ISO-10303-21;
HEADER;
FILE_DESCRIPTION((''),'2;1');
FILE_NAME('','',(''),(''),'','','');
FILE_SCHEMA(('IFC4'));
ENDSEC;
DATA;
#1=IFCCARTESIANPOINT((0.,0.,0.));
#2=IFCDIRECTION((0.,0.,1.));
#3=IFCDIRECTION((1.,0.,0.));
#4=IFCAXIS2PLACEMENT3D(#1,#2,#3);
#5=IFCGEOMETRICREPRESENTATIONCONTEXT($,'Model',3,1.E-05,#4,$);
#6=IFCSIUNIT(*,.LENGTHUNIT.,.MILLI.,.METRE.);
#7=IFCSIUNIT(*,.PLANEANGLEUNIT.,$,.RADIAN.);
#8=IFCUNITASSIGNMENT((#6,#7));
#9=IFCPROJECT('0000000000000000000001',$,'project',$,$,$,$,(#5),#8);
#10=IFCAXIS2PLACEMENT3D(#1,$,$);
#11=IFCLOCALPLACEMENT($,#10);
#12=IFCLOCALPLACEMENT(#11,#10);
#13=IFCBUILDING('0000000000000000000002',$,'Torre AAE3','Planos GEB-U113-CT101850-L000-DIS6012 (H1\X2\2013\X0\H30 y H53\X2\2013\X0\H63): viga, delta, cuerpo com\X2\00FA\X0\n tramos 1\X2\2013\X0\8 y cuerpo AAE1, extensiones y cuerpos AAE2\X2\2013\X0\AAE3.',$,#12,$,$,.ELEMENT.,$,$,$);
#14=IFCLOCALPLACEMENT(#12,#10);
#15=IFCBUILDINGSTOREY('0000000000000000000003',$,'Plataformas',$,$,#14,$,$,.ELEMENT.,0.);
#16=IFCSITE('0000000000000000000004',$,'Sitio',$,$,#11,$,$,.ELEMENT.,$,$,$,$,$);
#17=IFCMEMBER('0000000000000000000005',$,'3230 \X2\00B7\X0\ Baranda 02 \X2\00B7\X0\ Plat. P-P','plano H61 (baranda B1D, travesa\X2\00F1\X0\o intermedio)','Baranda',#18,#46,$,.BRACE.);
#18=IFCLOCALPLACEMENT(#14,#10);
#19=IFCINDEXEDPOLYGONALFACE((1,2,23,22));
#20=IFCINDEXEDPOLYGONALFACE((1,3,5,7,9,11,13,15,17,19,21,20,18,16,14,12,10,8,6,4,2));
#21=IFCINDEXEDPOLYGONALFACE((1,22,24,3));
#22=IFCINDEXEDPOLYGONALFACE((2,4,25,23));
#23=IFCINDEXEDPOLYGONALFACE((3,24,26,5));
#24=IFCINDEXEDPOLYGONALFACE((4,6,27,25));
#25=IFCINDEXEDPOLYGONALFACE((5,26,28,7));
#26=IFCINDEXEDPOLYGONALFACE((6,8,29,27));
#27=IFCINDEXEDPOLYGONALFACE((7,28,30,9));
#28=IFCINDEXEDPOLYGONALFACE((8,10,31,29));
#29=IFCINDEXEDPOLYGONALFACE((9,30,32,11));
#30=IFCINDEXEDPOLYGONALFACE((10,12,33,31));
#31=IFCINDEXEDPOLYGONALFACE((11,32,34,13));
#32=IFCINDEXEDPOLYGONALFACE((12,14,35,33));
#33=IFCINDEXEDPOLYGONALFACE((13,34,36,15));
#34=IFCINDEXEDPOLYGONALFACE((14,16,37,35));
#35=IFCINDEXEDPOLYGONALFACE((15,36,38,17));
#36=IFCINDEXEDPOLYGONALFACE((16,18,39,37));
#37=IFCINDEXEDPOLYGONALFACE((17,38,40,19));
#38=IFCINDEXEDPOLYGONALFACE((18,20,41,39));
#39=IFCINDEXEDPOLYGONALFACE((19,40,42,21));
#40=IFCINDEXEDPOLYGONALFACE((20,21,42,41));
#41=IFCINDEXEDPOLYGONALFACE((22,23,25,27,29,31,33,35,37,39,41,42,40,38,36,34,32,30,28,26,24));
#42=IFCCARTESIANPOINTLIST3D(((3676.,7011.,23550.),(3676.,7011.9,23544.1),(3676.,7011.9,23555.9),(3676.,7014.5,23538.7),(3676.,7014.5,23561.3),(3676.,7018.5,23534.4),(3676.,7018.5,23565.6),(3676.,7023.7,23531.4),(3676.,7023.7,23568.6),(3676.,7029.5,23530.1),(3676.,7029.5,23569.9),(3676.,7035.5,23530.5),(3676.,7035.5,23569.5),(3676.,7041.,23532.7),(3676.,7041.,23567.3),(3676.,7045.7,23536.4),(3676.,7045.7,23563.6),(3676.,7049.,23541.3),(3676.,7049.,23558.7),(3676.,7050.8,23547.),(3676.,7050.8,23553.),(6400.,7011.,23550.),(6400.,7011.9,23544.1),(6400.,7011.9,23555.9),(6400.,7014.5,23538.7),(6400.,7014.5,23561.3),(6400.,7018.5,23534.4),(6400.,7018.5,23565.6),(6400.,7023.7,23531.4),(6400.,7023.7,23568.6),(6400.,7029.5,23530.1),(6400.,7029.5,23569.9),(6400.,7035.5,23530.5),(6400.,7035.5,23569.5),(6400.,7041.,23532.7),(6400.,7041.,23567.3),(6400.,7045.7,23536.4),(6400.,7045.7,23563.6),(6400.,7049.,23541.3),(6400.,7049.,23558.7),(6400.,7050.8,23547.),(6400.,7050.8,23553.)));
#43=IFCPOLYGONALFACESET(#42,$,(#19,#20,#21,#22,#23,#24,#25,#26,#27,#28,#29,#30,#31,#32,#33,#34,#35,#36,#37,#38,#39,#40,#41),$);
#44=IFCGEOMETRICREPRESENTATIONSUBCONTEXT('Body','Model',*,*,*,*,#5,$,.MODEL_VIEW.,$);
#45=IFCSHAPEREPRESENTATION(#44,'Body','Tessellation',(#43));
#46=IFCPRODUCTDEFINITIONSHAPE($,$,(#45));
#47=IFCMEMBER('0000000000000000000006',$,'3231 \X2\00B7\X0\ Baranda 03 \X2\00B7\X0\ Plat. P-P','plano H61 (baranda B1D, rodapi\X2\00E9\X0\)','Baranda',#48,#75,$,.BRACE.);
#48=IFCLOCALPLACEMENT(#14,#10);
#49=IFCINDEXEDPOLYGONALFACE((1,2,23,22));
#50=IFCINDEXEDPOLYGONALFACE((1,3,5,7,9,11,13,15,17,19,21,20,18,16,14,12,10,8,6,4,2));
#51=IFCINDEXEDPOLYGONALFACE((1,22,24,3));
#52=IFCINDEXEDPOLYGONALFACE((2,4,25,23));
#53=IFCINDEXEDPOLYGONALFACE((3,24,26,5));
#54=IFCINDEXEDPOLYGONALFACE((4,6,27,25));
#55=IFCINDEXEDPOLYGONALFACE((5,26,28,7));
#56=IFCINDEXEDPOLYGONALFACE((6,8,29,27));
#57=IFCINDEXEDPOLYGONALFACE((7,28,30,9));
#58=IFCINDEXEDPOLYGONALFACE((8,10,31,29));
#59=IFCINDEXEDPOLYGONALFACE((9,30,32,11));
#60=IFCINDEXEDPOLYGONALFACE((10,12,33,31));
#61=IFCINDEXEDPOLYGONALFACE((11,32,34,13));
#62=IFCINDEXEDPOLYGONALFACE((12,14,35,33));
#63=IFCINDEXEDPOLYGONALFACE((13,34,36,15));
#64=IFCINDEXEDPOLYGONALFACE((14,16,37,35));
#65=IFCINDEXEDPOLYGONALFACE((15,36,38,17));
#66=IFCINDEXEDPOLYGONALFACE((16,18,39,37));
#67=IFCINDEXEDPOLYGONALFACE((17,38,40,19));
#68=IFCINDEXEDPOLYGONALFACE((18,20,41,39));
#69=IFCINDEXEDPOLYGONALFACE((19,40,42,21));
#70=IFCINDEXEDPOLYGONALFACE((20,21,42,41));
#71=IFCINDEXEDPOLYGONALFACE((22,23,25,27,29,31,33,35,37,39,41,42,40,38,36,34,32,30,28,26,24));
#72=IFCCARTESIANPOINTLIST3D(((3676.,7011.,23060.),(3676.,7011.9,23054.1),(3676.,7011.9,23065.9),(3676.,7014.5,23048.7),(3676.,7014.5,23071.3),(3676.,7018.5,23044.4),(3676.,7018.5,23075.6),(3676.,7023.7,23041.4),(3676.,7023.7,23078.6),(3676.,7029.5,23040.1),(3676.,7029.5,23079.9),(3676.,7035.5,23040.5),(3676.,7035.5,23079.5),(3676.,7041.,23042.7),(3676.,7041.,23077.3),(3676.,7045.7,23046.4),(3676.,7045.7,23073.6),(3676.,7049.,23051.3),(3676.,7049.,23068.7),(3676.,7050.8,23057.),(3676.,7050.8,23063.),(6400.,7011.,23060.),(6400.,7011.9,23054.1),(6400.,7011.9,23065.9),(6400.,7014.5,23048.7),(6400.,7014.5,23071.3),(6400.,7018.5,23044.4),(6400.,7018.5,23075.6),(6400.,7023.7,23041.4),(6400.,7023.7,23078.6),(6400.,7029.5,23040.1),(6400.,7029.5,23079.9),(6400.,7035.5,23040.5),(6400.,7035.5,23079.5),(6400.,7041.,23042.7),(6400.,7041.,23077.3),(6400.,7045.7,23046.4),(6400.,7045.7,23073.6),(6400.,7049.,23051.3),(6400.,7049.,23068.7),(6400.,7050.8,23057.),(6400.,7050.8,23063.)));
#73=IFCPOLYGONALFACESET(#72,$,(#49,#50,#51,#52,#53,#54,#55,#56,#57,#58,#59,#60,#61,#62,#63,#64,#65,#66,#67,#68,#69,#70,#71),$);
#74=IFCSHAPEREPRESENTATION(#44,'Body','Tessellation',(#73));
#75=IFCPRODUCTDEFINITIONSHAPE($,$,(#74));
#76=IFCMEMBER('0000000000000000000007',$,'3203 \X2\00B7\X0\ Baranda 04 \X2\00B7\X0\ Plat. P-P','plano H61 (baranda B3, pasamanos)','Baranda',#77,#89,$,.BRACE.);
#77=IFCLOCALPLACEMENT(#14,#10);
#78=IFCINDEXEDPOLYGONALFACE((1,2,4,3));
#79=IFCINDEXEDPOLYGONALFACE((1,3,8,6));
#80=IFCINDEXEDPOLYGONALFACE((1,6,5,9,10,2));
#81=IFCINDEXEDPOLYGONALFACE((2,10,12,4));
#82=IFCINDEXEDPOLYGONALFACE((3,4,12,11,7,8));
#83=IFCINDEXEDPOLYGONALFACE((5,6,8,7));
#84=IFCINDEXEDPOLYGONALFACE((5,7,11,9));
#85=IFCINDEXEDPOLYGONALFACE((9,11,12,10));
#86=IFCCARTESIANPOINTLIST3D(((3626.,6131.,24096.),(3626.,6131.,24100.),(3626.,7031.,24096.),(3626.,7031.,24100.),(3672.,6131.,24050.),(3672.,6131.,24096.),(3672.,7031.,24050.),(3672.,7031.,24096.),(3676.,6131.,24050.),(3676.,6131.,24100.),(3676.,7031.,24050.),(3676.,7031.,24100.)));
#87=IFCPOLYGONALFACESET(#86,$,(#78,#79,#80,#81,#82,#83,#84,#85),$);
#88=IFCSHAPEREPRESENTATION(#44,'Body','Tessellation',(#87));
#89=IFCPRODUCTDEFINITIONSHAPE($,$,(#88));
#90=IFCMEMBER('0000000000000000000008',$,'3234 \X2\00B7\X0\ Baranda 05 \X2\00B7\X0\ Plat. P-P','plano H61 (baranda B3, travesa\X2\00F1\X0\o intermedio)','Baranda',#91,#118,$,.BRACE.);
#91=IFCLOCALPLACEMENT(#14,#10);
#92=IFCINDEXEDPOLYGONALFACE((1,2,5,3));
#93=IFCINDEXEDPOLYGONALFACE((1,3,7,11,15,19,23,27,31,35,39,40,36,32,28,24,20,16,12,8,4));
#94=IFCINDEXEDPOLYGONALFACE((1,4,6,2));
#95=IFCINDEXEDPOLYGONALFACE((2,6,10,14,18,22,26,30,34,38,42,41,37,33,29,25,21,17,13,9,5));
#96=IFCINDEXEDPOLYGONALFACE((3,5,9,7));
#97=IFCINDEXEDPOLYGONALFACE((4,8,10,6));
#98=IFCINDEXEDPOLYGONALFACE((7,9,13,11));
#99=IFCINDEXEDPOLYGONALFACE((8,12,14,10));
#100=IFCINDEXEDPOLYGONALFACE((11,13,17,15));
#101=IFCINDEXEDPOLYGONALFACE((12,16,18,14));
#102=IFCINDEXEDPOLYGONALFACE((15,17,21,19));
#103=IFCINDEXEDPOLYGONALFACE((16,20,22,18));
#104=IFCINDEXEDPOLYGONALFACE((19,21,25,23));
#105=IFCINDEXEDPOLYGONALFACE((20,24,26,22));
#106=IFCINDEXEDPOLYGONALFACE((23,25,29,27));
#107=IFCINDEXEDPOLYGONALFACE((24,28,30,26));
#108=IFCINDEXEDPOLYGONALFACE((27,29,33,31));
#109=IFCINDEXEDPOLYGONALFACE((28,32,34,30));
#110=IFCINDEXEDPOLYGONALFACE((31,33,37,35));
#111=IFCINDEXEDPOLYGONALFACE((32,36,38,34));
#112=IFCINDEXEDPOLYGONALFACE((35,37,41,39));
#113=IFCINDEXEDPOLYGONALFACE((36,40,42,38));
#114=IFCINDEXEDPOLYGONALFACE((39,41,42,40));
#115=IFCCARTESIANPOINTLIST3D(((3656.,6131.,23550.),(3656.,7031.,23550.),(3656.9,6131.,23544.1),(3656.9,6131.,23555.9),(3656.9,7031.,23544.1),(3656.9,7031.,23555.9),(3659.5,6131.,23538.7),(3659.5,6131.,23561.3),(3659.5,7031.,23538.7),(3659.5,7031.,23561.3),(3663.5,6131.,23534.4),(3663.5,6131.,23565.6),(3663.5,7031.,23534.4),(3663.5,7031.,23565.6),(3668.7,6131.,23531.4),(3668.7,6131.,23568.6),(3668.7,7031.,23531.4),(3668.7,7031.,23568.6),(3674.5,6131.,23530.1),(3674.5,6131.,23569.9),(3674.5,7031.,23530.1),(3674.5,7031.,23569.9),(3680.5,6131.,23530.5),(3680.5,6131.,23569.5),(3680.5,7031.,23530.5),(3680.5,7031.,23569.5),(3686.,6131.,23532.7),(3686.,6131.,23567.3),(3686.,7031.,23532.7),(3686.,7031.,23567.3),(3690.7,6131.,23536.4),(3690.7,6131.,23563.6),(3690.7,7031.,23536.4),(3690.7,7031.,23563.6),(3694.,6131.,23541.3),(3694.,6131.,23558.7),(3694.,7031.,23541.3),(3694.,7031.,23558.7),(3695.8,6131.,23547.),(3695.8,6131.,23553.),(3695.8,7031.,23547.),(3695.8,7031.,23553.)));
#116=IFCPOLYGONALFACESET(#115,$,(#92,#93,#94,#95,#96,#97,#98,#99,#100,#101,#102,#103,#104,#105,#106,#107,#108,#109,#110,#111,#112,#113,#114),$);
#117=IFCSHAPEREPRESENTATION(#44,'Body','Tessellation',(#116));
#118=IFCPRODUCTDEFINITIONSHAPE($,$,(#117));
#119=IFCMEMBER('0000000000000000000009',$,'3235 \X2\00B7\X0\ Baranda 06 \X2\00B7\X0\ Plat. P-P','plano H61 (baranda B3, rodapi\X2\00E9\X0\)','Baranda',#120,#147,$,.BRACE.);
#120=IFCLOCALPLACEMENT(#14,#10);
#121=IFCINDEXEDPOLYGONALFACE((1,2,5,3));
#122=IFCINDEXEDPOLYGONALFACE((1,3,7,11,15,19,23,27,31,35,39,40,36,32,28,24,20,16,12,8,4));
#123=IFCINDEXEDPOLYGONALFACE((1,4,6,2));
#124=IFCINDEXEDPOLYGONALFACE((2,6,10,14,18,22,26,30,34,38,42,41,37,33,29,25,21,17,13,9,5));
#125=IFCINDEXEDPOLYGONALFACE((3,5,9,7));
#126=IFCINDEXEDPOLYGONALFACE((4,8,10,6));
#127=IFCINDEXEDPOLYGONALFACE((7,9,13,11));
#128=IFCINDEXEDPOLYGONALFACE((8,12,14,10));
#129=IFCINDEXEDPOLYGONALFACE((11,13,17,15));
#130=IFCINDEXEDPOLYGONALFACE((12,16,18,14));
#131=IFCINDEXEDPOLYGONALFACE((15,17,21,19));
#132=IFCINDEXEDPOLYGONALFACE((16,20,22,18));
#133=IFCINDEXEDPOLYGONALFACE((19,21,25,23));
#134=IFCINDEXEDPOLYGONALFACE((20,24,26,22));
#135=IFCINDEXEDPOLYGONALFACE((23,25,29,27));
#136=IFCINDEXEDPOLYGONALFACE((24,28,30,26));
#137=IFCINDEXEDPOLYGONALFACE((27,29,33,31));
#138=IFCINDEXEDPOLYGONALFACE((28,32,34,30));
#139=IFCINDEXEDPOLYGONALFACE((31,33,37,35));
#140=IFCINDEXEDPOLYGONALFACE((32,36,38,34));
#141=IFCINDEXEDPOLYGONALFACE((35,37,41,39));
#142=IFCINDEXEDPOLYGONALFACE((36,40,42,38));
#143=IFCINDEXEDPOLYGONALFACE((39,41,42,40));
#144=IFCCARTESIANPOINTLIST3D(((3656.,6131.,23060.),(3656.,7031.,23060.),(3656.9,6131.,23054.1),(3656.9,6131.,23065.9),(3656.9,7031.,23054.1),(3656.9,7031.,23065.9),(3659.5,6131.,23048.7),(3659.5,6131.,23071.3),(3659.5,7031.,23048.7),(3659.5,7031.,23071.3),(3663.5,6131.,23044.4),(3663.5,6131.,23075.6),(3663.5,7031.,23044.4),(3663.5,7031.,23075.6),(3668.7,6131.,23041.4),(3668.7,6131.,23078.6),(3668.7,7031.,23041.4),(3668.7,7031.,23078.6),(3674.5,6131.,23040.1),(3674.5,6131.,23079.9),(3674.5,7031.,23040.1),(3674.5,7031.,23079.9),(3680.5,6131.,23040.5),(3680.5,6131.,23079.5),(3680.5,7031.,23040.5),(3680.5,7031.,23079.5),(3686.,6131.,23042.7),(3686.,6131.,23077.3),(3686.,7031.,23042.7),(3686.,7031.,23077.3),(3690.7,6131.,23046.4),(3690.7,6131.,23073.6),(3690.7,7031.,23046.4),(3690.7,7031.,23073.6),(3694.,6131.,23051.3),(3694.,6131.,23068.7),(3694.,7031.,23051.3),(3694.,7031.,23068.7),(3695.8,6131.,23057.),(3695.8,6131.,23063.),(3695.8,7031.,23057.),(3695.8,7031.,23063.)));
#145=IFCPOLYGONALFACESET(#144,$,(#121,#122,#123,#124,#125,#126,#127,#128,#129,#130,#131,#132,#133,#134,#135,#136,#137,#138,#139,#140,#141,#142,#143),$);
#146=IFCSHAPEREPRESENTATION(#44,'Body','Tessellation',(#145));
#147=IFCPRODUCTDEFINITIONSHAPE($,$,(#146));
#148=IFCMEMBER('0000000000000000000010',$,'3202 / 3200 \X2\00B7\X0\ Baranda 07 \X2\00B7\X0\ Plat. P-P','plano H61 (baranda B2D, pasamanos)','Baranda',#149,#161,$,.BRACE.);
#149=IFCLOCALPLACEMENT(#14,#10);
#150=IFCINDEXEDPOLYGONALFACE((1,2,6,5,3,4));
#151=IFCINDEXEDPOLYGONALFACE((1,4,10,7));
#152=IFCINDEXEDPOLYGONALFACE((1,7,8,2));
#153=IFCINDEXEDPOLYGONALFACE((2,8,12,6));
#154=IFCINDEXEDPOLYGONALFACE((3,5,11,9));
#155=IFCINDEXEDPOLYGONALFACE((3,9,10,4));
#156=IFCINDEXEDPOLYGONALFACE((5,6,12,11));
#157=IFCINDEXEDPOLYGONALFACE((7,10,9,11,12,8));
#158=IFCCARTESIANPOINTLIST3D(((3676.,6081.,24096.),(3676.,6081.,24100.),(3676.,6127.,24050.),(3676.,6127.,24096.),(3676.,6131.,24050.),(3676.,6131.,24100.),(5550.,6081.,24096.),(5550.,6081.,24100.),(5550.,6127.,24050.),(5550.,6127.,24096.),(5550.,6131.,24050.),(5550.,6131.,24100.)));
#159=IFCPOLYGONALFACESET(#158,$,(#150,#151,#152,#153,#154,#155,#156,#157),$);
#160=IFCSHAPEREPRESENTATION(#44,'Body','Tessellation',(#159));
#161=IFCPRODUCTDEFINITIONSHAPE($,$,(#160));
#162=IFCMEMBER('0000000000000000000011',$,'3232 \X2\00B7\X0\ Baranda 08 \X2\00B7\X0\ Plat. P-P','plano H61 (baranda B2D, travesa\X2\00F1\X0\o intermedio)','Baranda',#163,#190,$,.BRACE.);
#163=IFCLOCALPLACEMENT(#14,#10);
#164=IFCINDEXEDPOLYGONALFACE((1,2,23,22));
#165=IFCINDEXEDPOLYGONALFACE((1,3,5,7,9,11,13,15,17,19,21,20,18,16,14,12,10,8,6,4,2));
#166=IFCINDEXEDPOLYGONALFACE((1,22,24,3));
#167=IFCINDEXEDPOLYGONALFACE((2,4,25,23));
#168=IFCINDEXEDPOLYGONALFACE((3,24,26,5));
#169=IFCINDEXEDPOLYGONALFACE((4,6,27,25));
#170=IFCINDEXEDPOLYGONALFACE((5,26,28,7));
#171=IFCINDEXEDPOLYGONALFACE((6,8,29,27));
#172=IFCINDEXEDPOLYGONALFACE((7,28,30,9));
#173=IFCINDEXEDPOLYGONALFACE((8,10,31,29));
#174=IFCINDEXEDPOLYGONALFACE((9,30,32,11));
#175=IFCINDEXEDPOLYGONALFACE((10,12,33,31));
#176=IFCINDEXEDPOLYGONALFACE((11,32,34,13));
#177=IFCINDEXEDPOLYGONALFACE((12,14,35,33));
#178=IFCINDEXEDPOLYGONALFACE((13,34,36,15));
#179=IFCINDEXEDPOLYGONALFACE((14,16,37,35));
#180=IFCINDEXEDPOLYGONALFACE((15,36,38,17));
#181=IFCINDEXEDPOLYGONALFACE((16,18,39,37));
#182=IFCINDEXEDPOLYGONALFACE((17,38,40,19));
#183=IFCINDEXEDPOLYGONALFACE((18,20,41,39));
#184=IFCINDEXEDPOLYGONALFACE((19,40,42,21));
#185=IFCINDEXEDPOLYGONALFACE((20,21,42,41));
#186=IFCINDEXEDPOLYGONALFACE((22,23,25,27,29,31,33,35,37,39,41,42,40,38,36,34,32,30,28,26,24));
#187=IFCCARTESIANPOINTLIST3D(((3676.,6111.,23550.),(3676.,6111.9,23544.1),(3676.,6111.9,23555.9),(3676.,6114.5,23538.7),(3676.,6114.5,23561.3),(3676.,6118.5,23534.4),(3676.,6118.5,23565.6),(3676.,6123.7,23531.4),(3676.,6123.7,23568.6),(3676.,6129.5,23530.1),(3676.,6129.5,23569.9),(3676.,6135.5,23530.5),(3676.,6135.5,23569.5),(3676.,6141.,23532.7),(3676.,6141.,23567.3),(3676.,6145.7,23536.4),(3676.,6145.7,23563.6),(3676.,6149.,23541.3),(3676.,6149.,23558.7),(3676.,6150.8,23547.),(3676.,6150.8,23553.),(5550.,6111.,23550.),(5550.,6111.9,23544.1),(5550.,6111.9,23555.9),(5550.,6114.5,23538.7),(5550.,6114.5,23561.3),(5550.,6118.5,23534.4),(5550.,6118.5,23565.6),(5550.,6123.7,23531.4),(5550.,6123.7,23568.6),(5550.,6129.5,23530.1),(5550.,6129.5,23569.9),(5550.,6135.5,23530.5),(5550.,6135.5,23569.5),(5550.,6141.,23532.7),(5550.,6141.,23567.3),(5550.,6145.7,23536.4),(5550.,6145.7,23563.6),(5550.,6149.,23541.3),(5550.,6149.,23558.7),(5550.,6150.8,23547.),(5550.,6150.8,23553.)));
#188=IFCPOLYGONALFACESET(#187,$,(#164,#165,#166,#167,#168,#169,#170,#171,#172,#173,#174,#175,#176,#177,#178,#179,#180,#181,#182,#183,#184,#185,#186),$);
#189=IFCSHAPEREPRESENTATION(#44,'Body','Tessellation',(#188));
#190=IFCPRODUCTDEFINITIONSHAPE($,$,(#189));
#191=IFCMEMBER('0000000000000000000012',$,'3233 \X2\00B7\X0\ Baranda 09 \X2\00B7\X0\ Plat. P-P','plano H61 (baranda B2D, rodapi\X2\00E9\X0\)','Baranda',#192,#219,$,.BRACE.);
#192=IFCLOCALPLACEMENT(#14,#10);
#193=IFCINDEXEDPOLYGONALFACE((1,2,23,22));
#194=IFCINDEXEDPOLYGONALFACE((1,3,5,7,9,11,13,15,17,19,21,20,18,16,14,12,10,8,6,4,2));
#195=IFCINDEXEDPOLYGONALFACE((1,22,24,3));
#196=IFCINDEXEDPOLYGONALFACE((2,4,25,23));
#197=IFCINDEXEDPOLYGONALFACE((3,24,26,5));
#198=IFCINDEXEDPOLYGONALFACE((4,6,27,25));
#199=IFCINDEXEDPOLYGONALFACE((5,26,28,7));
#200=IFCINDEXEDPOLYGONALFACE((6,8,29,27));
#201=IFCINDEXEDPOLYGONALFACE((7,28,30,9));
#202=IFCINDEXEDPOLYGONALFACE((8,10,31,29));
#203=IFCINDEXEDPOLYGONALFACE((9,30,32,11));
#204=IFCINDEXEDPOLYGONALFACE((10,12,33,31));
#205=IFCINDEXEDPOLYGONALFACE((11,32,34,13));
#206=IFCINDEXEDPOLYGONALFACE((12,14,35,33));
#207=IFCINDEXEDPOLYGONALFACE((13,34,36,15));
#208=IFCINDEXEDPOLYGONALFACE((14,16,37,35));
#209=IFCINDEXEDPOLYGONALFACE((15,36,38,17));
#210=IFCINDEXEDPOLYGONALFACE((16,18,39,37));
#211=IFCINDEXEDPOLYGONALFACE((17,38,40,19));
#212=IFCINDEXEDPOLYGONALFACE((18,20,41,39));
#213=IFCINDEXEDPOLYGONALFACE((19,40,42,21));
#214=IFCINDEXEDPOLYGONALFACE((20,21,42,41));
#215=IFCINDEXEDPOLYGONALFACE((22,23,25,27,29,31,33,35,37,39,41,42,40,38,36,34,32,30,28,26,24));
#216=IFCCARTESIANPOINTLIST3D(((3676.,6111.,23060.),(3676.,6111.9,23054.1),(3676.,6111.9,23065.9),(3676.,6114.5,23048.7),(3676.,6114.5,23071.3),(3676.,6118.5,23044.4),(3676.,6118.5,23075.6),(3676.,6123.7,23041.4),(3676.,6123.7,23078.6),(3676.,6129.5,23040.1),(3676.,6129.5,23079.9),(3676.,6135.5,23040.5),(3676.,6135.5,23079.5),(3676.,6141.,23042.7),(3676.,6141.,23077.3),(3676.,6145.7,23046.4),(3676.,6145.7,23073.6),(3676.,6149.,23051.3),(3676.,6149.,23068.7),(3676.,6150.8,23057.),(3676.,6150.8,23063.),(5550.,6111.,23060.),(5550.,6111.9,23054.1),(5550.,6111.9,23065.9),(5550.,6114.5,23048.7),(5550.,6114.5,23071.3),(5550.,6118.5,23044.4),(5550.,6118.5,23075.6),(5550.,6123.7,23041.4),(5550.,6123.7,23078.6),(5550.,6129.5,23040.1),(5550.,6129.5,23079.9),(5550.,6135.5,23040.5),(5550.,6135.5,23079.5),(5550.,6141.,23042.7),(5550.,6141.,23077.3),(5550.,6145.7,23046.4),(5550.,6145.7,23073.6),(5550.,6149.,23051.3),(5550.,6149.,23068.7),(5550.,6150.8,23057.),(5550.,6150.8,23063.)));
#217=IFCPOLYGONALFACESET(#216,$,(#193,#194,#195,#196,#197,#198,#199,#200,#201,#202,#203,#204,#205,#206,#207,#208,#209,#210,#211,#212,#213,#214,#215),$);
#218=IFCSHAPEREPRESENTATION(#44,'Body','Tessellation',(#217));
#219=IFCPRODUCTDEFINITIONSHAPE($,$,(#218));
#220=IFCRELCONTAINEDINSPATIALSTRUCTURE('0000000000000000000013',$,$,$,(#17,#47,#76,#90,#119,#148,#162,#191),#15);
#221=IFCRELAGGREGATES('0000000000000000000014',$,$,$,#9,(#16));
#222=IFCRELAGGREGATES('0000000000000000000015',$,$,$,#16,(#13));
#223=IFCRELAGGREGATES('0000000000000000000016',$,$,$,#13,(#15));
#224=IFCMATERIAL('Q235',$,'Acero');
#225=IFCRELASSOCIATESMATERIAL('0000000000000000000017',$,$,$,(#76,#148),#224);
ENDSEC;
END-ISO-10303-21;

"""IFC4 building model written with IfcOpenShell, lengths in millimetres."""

from ifc_helpers import new_model, si_unit, frame, frame_2d, origin, origin_with_axes, place, context, subcontext, project, spatial, circle, l_section, extrude, material, element, save


model = new_model("IFC4")

# Units and contexts
model_context = context("Model", 3, precision=1e-05, world=origin_with_axes())
body_context = subcontext(model_context, "Body", "Model", "MODEL_VIEW")
ifc_project = project(units=[si_unit("LENGTHUNIT", "METRE", prefix="MILLI"), si_unit("PLANEANGLEUNIT", "RADIAN")], contexts=[model_context])

# Site, building, storey
site_placement = place(None, origin())
site = spatial("IfcSite", under=ifc_project, at=site_placement, Name="Sitio", CompositionType="ELEMENT")
building_placement = place(site_placement, origin())
building = spatial("IfcBuilding", under=site, at=building_placement, Name="Torre AAE3", Description="Planos GEB-U113-CT101850-L000-DIS6012 (H1–H30 y H53–H63): viga, delta, cuerpo común tramos 1–8 y cuerpo AAE1, extensiones y cuerpos AAE2–AAE3.", CompositionType="ELEMENT")
storey_placement = place(building_placement, origin())
storey = spatial("IfcBuildingStorey", under=building, at=storey_placement, Name="Plataformas", CompositionType="ELEMENT", Elevation=0.0)

# Members
ifc_material = material(Name="Q235", Category="Acero")
for number, where, z_axis, x_axis, name, description in (
    (1, (6400.0, 7031.0, 23550.0), (-1.0, 0.0, 0.0), (0.0, -1.0, 0.0), "3230 · Baranda 02 · Plat. P-P", "plano H61 (baranda B1D, travesaño intermedio)"),
    (2, (6400.0, 7031.0, 23060.0), (-1.0, 0.0, 0.0), (0.0, -1.0, 0.0), "3231 · Baranda 03 · Plat. P-P", "plano H61 (baranda B1D, rodapié)"),
):
    element("IfcMember", number, at=place(storey_placement, frame(where, z_axis=z_axis, x_axis=x_axis)), inside=storey, Name=name, Description=description, ObjectType="Baranda", PredefinedType="BRACE", context=body_context, shape_type="SweptSolid", body=[
        extrude(circle(Radius=20.0), None, (0.0, 0.0, 1.0), 2724.0),
    ])
member_1_placement = place(storey_placement, frame((3676.0, 7031.0, 24100.0), z_axis=(0.0, -1.0, 0.0), x_axis=(-1.0, 0.0, 0.0)))
element("IfcMember", 3, at=member_1_placement, inside=storey, material=ifc_material, Name="3203 · Baranda 04 · Plat. P-P", Description="plano H61 (baranda B3, pasamanos)", ObjectType="Baranda", PredefinedType="BRACE", context=body_context, shape_type="SweptSolid", body=[
    extrude(l_section(Depth=50.0, Width=50.0, Thickness=4.0, at=frame_2d((25.0, 25.0))), None, (0.0, 0.0, 1.0), 900.0),
])
for number, where, z_axis, x_axis, name, description in (
    (4, (3676.0, 7031.0, 23550.0), (0.0, -1.0, 0.0), (-1.0, 0.0, 0.0), "3234 · Baranda 05 · Plat. P-P", "plano H61 (baranda B3, travesaño intermedio)"),
    (5, (3676.0, 7031.0, 23060.0), (0.0, -1.0, 0.0), (-1.0, 0.0, 0.0), "3235 · Baranda 06 · Plat. P-P", "plano H61 (baranda B3, rodapié)"),
):
    element("IfcMember", number, at=place(storey_placement, frame(where, z_axis=z_axis, x_axis=x_axis)), inside=storey, Name=name, Description=description, ObjectType="Baranda", PredefinedType="BRACE", context=body_context, shape_type="SweptSolid", body=[
        extrude(circle(Radius=20.0), None, (0.0, 0.0, 1.0), 900.0),
    ])
member_2_placement = place(storey_placement, frame((3676.0, 6131.0, 24100.0), z_axis=(1.0, 0.0, 0.0), x_axis=(0.0, -1.0, 0.0)))
element("IfcMember", 6, at=member_2_placement, inside=storey, material=ifc_material, Name="3202 / 3200 · Baranda 07 · Plat. P-P", Description="plano H61 (baranda B2D, pasamanos)", ObjectType="Baranda", PredefinedType="BRACE", context=body_context, shape_type="SweptSolid", body=[
    extrude(l_section(Depth=50.0, Width=50.0, Thickness=4.0, at=frame_2d((25.0, 25.0))), None, (0.0, 0.0, 1.0), 1874.0),
])
for number, where, z_axis, x_axis, name, description in (
    (7, (3676.0, 6131.0, 23550.0), (1.0, 0.0, 0.0), (0.0, -1.0, 0.0), "3232 · Baranda 08 · Plat. P-P", "plano H61 (baranda B2D, travesaño intermedio)"),
    (8, (3676.0, 6131.0, 23060.0), (1.0, 0.0, 0.0), (0.0, -1.0, 0.0), "3233 · Baranda 09 · Plat. P-P", "plano H61 (baranda B2D, rodapié)"),
):
    element("IfcMember", number, at=place(storey_placement, frame(where, z_axis=z_axis, x_axis=x_axis)), inside=storey, Name=name, Description=description, ObjectType="Baranda", PredefinedType="BRACE", context=body_context, shape_type="SweptSolid", body=[
        extrude(circle(Radius=20.0), None, (0.0, 0.0, 1.0), 1874.0),
    ])

save(model, "model.ifc")
